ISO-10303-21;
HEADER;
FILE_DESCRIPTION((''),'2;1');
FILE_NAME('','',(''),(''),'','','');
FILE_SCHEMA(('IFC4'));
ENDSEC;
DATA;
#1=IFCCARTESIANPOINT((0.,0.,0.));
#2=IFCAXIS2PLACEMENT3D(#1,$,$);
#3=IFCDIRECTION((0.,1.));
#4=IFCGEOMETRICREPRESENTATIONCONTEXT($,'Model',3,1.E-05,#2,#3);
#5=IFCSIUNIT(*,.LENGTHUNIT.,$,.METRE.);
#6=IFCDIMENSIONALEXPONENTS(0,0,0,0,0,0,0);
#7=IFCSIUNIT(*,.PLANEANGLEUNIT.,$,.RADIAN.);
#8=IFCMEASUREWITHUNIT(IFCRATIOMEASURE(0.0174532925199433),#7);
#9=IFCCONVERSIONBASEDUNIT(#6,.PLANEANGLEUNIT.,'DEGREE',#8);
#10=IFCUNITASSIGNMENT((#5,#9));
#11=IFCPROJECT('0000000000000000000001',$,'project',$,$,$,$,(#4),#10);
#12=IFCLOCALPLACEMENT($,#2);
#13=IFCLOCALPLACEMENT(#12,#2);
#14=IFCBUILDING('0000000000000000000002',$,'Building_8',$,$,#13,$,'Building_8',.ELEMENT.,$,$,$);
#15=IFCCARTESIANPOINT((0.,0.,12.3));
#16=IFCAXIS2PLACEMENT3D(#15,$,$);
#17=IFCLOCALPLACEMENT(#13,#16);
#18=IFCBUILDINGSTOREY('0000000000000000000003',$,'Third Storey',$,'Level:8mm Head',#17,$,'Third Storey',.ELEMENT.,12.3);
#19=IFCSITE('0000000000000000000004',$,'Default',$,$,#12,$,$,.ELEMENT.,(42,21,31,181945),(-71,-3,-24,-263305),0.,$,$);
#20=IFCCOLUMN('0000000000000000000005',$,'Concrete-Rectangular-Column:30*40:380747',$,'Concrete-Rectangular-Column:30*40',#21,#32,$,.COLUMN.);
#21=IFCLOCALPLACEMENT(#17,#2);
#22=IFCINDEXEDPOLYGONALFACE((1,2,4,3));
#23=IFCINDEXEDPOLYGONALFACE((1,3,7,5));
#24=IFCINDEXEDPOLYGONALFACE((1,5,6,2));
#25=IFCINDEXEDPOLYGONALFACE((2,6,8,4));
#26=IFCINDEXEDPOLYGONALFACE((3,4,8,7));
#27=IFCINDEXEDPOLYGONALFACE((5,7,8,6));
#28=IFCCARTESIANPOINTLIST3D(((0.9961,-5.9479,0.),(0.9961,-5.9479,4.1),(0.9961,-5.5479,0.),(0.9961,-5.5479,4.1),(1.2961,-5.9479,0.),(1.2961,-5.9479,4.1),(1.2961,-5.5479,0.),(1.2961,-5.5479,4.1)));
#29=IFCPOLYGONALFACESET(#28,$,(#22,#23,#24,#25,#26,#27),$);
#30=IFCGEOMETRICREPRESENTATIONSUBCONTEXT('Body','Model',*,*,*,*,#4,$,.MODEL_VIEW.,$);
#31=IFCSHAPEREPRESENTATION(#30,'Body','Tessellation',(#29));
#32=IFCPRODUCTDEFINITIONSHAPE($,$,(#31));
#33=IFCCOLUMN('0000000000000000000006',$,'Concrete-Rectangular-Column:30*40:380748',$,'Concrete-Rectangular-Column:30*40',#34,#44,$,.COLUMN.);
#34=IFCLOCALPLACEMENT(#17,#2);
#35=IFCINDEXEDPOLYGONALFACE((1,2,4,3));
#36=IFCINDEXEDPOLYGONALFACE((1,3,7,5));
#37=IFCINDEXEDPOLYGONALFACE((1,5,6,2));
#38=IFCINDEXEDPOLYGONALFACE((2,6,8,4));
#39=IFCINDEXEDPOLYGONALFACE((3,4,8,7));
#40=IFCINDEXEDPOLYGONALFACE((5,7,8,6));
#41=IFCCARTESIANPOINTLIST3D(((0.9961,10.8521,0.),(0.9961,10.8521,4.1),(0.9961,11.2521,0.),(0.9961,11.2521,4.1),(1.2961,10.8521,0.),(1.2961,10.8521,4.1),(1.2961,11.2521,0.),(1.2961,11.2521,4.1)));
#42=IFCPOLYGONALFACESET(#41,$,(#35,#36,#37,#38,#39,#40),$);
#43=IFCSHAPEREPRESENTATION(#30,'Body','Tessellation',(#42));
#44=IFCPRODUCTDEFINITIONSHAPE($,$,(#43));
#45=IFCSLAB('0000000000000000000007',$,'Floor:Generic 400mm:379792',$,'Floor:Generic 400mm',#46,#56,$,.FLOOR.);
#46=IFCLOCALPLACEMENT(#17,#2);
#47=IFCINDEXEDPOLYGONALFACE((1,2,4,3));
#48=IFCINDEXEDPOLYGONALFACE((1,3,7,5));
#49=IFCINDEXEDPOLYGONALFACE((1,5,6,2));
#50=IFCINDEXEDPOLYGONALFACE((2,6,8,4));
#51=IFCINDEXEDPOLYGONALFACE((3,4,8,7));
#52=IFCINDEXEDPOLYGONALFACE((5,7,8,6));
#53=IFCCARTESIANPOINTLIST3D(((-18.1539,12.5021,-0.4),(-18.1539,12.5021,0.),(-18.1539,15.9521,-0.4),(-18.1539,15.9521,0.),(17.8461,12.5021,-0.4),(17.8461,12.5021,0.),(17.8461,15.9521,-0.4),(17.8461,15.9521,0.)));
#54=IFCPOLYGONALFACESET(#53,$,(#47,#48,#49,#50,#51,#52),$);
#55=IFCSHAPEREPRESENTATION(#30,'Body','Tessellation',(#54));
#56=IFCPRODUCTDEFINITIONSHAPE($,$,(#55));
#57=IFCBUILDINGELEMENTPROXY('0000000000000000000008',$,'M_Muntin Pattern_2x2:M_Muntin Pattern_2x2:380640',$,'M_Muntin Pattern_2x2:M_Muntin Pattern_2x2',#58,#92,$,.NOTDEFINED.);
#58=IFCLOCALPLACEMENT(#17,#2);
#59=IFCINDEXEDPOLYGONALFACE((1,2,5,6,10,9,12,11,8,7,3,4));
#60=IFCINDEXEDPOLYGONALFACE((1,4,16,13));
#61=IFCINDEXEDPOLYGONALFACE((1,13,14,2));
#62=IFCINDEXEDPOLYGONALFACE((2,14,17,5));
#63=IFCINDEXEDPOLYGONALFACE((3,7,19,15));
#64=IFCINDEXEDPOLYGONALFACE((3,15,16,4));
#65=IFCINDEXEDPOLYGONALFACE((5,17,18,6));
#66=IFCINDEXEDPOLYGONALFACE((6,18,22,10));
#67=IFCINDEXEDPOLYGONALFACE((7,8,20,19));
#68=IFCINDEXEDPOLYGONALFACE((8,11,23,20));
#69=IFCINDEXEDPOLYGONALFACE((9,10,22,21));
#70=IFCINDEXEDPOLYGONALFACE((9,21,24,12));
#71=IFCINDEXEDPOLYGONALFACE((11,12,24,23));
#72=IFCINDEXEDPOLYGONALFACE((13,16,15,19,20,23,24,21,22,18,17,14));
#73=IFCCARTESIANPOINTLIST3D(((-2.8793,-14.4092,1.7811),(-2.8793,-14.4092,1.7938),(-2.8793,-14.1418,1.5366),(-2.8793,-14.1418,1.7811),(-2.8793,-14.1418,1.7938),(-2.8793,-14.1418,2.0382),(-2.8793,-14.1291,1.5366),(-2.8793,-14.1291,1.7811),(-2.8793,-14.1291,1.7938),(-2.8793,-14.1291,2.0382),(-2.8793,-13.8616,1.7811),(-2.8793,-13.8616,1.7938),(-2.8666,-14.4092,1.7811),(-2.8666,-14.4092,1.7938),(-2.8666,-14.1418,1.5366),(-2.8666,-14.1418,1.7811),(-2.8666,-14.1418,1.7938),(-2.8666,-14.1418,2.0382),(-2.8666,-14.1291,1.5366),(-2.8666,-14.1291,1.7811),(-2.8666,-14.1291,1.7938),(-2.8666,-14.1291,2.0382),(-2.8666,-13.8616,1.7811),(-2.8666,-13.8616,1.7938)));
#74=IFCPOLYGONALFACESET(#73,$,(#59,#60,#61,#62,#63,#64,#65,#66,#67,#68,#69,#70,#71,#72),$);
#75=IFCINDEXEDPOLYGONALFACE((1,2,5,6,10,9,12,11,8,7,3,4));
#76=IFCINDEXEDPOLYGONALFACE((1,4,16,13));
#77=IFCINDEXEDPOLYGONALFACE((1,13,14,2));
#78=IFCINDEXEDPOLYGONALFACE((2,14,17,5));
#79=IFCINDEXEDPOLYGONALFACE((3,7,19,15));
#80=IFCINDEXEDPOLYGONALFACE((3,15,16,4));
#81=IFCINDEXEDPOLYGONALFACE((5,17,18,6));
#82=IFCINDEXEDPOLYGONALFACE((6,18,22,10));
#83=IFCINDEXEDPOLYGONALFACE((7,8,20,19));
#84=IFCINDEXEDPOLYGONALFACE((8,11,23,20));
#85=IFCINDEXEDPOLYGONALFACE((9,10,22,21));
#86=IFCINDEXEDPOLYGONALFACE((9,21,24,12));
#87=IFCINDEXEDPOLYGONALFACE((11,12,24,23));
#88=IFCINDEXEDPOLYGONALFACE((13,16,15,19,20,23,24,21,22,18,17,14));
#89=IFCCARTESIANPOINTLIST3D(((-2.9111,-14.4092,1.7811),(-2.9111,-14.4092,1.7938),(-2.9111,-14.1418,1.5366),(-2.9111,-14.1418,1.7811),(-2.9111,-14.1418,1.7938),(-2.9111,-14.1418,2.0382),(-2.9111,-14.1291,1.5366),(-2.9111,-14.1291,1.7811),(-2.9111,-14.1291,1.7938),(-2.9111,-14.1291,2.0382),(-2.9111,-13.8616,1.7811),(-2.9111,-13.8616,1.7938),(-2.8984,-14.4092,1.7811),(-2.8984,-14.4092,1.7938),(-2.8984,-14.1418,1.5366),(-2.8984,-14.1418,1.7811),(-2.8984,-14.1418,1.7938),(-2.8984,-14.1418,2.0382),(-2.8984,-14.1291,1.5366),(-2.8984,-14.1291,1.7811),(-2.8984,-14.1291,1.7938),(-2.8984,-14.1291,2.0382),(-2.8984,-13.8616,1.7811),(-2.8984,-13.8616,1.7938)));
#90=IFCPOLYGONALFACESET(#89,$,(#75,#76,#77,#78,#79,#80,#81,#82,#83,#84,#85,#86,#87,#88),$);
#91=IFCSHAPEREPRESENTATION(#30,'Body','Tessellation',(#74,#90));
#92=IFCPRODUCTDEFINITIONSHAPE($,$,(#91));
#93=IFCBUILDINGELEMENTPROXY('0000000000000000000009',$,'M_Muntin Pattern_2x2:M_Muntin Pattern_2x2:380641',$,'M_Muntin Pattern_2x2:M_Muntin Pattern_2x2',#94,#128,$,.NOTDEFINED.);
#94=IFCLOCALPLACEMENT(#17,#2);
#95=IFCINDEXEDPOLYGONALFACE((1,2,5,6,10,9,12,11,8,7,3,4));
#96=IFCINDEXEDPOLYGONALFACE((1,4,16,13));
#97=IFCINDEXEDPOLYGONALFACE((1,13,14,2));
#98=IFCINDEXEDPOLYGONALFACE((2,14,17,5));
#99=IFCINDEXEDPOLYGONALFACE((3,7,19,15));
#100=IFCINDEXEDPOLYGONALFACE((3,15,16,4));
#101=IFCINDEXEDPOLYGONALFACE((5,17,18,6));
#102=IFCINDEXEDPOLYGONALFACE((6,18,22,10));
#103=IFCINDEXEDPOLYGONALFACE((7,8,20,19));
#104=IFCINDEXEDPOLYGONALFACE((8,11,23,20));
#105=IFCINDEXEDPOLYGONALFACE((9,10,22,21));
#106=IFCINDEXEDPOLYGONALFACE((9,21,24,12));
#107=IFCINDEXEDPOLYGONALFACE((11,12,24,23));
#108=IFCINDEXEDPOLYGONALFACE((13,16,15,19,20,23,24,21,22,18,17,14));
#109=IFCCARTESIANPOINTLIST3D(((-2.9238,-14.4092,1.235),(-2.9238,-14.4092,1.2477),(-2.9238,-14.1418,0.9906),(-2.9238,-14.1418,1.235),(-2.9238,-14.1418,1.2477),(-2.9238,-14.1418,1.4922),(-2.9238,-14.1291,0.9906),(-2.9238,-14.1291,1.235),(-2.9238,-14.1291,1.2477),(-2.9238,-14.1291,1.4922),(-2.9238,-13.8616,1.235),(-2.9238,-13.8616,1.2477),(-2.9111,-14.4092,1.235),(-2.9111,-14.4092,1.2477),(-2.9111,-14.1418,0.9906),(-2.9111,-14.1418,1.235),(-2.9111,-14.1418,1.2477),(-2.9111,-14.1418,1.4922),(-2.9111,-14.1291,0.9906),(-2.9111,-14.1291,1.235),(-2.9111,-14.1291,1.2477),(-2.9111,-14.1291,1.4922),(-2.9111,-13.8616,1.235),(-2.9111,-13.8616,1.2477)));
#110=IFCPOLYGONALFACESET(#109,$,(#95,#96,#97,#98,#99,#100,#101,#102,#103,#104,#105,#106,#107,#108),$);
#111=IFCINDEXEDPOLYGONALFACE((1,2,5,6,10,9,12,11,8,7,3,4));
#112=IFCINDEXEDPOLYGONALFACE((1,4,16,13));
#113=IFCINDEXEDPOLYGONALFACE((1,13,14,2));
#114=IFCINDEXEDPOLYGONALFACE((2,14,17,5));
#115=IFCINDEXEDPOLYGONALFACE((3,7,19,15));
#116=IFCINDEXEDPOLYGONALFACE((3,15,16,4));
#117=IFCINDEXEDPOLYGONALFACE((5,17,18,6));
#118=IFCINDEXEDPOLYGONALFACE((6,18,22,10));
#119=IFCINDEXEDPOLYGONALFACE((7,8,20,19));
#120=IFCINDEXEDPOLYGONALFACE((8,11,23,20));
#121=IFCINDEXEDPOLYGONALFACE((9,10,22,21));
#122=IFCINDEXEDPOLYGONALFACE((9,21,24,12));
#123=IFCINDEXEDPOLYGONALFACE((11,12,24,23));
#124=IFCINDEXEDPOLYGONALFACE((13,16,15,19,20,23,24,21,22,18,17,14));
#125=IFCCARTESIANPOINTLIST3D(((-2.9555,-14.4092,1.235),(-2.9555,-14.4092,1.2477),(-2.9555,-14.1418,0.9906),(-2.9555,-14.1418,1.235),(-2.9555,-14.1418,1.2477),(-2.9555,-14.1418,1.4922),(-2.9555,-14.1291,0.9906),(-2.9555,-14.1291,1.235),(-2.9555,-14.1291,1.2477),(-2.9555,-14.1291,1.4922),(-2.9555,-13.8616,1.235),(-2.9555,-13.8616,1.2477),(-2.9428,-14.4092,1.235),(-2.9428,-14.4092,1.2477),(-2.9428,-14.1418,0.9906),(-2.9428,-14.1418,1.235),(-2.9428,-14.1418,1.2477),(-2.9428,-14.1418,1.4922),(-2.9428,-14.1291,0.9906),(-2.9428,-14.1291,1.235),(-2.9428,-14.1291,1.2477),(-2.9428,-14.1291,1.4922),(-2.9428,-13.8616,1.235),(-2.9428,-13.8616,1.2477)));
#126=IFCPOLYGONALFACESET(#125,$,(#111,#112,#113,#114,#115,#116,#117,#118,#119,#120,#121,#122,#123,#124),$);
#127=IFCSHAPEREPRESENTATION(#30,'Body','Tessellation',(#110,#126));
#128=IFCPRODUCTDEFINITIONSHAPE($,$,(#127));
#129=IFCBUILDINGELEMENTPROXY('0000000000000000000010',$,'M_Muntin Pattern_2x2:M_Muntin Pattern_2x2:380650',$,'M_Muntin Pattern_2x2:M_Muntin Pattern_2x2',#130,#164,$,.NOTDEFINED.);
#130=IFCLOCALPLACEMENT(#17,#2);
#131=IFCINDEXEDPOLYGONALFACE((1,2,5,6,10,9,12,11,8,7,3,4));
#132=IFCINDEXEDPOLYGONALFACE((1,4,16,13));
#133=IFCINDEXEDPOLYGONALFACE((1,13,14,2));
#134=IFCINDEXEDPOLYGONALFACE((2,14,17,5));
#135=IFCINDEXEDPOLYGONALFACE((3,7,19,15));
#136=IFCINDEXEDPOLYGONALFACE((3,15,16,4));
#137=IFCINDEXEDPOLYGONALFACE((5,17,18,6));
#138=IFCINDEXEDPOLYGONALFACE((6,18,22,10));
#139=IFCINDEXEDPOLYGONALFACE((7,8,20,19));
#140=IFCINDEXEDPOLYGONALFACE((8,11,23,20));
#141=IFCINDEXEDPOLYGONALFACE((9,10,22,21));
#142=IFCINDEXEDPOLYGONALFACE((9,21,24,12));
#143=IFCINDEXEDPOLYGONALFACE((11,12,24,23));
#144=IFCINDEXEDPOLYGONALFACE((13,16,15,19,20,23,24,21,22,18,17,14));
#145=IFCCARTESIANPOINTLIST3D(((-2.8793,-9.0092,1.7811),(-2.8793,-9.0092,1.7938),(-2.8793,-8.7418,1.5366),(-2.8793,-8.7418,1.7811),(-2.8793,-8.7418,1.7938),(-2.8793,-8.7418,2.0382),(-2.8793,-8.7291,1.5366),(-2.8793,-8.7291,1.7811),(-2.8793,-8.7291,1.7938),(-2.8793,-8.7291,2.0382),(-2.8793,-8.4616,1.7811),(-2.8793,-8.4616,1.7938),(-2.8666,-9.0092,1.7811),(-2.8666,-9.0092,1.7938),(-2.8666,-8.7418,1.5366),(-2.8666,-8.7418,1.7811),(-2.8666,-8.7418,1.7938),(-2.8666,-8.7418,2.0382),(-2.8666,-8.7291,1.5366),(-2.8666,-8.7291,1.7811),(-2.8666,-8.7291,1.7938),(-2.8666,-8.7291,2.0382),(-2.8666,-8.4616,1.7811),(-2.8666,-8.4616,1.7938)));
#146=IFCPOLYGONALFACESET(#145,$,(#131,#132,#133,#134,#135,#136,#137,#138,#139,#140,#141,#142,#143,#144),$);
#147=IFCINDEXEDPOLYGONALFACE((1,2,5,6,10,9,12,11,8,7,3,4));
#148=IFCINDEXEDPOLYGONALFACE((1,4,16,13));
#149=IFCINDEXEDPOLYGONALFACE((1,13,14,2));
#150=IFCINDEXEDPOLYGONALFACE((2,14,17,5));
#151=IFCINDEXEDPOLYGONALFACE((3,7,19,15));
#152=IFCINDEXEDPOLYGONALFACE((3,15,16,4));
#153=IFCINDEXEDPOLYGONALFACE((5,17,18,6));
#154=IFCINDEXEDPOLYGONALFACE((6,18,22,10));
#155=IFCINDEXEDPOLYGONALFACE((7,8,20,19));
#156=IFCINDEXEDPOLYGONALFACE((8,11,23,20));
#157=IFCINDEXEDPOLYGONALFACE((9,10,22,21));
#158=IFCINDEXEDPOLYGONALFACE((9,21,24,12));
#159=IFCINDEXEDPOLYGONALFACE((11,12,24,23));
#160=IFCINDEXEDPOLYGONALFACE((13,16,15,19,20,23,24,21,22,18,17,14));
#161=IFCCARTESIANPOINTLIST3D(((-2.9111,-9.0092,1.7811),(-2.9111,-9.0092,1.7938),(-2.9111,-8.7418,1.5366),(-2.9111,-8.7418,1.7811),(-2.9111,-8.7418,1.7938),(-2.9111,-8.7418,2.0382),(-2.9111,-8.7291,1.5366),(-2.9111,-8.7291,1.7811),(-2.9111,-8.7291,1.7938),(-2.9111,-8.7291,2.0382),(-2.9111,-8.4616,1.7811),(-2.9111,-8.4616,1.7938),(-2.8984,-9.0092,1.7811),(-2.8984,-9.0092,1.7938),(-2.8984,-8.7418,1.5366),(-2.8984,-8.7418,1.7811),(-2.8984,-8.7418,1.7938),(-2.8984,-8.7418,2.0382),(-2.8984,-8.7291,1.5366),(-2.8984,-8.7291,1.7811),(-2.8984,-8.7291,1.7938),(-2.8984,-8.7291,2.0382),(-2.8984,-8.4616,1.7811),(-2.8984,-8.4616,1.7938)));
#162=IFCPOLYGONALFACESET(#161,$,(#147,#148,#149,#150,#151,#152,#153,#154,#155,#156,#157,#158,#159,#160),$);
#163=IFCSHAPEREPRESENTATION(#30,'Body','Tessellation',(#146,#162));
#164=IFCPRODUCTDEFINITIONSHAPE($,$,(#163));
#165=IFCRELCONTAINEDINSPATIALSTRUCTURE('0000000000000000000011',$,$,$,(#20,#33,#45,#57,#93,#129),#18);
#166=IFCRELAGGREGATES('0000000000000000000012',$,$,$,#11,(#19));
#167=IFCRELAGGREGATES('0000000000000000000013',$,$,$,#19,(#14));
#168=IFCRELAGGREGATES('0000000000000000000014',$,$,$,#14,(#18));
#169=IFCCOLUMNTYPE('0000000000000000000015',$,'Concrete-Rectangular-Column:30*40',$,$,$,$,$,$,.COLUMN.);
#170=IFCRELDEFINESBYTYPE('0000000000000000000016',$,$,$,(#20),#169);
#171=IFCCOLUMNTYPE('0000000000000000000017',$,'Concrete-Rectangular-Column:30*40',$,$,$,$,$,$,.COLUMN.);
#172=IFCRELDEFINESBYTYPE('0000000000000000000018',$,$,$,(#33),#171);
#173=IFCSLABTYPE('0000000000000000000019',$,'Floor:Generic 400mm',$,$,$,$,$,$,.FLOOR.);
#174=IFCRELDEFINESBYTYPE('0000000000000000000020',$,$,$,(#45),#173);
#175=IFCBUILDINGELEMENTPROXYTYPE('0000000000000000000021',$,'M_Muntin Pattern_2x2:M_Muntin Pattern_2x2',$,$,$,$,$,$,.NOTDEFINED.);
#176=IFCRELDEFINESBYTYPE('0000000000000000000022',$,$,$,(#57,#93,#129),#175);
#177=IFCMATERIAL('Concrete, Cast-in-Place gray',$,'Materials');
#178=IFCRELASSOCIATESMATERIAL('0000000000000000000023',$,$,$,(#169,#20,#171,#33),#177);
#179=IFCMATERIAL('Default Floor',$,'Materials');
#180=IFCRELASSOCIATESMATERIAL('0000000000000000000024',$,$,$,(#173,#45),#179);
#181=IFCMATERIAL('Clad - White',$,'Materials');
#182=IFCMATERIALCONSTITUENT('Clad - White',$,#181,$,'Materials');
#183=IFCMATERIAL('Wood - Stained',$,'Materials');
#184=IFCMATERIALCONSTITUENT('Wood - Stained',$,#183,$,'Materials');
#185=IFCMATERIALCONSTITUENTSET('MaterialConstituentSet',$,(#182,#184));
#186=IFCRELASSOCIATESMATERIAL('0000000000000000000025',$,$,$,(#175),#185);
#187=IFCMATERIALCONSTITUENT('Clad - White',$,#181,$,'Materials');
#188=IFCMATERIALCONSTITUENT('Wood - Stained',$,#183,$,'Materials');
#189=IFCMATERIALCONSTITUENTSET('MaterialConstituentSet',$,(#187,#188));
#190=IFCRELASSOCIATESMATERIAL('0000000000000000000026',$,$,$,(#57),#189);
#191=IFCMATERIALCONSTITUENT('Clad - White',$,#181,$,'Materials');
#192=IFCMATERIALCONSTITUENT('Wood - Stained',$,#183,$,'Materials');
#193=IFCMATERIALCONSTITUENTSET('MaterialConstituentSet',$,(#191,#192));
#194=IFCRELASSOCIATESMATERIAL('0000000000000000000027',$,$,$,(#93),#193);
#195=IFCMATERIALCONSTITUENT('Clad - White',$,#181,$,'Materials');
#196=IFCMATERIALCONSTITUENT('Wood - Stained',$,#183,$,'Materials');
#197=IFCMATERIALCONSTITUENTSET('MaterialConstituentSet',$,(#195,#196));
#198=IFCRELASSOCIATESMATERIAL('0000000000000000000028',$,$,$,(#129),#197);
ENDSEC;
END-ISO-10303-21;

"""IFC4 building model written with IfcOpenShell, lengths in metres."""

from ifc_helpers import new_model, entity, si_unit, converted_unit, direction, frame, origin, place, context, subcontext, project, spatial, indexed_curve, outline, extrude, source, transform, mapped, material, constituent, constituent_set, type_object, type_shapes, element, save


model = new_model("IFC4")

# Units and contexts
model_context = context("Model", 3, precision=1e-05, world=origin(), true_north=direction((0.0, 1.0)))
body_context = subcontext(model_context, "Body", "Model", "MODEL_VIEW")
ifc_project = project(units=[si_unit("LENGTHUNIT", "METRE"), converted_unit("PLANEANGLEUNIT", "DEGREE", entity("IfcRatioMeasure", 0.0174532925199433), si_unit("PLANEANGLEUNIT", "RADIAN"), dimensions=[0, 0, 0, 0, 0, 0, 0])], contexts=[model_context])

# Site, building, storey
site_placement = place(None, origin())
site = spatial("IfcSite", under=ifc_project, at=site_placement, Name="Default", CompositionType="ELEMENT", RefLatitude=(42, 21, 31, 181945), RefLongitude=(-71, -3, -24, -263305), RefElevation=0.0)
building_placement = place(site_placement, origin())
building = spatial("IfcBuilding", under=site, at=building_placement, Name="Building_8", LongName="Building_8", CompositionType="ELEMENT")
storey_placement = place(building_placement, frame((0.0, 0.0, 12.3)))
storey = spatial("IfcBuildingStorey", under=building, at=storey_placement, Name="Third Storey", ObjectType="Level:8mm Head", LongName="Third Storey", CompositionType="ELEMENT", Elevation=12.3)

# Columns
ifc_material_1 = material(Name="Concrete, Cast-in-Place gray", Category="Materials")
column_type_1 = type_object("IfcColumnType", Name="Concrete-Rectangular-Column:30*40", PredefinedType="COLUMN", material=ifc_material_1)
shared_shape_1 = source(origin(), body_context, "Body", "SweptSolid", [
    extrude(outline(indexed_curve([(-0.2, -0.15), (0.2, -0.15), (0.2, 0.15), (-0.2, 0.15), (-0.2, -0.15)], self_intersect=False)), frame((1.1461, -5.7479, 12.3), z_axis=(0.0, 0.0, 1.0), x_axis=(0.0, -1.0, 0.0)), (0.0, 0.0, 1.0), 4.1),
])
type_shapes(column_type_1, [shared_shape_1])
column_1_placement = place(storey_placement, frame((0.0, 0.0, -12.3)))
element("IfcColumn", 1, at=column_1_placement, inside=storey, type_object=column_type_1, material=ifc_material_1, Name="Concrete-Rectangular-Column:30*40:380747", ObjectType="Concrete-Rectangular-Column:30*40", PredefinedType="COLUMN", context=body_context, shape_type="MappedRepresentation", body=[
    mapped(shared_shape_1, transform((0.0, 0.0, 0.0), scale=1.0)),
])
column_type_2 = type_object("IfcColumnType", Name="Concrete-Rectangular-Column:30*40", PredefinedType="COLUMN", material=ifc_material_1)
shared_shape_2 = source(origin(), body_context, "Body", "SweptSolid", [
    extrude(outline(indexed_curve([(-0.2, -0.15), (0.2, -0.15), (0.2, 0.15), (-0.2, 0.15), (-0.2, -0.15)], self_intersect=False)), frame((1.1461, 11.0521, 12.3), z_axis=(0.0, 0.0, 1.0), x_axis=(0.0, -1.0, 0.0)), (0.0, 0.0, 1.0), 4.1),
])
type_shapes(column_type_2, [shared_shape_2])
column_2_placement = place(storey_placement, frame((0.0, 0.0, -12.3)))
element("IfcColumn", 2, at=column_2_placement, inside=storey, type_object=column_type_2, material=ifc_material_1, Name="Concrete-Rectangular-Column:30*40:380748", ObjectType="Concrete-Rectangular-Column:30*40", PredefinedType="COLUMN", context=body_context, shape_type="MappedRepresentation", body=[
    mapped(shared_shape_2, transform((0.0, 0.0, 0.0), scale=1.0)),
])

# Slab
ifc_material_2 = material(Name="Default Floor", Category="Materials")
slab_type_1 = type_object("IfcSlabType", Name="Floor:Generic 400mm", PredefinedType="FLOOR", material=ifc_material_2)
slab_1_placement = place(storey_placement, origin())
element("IfcSlab", 3, at=slab_1_placement, inside=storey, type_object=slab_type_1, material=ifc_material_2, Name="Floor:Generic 400mm:379792", ObjectType="Floor:Generic 400mm", PredefinedType="FLOOR", context=body_context, shape_type="SweptSolid", body=[
    extrude(outline(indexed_curve([(-1.725, -18.0), (1.725, -18.0), (1.725, 18.0), (-1.725, 18.0), (-1.725, -18.0)], self_intersect=False)), frame((-0.1539, 14.2271, 0.0), z_axis=(0.0, 0.0, -1.0), x_axis=(0.0, 1.0, 0.0)), (0.0, 0.0, 1.0), 0.4),
])

# Building element proxies
ifc_material_3 = material(Name="Clad - White", Category="Materials")
ifc_constituent_1 = constituent(ifc_material_3, Name="Clad - White", Category="Materials")
ifc_material_4 = material(Name="Wood - Stained", Category="Materials")
ifc_constituent_2 = constituent(ifc_material_4, Name="Wood - Stained", Category="Materials")
ifc_constituent_set_1 = constituent_set(constituents=[ifc_constituent_1, ifc_constituent_2], Name="MaterialConstituentSet")
ifc_constituent_3 = constituent(ifc_material_3, Name="Clad - White", Category="Materials")
ifc_constituent_4 = constituent(ifc_material_4, Name="Wood - Stained", Category="Materials")
ifc_constituent_set_2 = constituent_set(constituents=[ifc_constituent_3, ifc_constituent_4], Name="MaterialConstituentSet")
building_element_proxy_type_1 = type_object("IfcBuildingElementProxyType", Name="M_Muntin Pattern_2x2:M_Muntin Pattern_2x2", PredefinedType="NOTDEFINED", material=ifc_constituent_set_2)
shared_shape_3 = source(origin(), body_context, "Body", "SweptSolid", [
    extrude(outline(indexed_curve([(0.0064, -0.0064), (0.2508, -0.0064), (0.2508, 0.0063), (0.0064, 0.0063), (0.0064, 0.2738), (-0.0063, 0.2738), (-0.0063, 0.0063), (-0.2508, 0.0063), (-0.2508, -0.0064), (-0.0063, -0.0064), (-0.0063, -0.2738), (0.0064, -0.2738), (0.0064, -0.0064)], self_intersect=False)), frame((0.0, 0.0095, 0.2508), z_axis=(0.0, 1.0, 0.0), x_axis=(0.0, 0.0, 1.0)), (0.0, 0.0, 1.0), 0.0127),
    extrude(outline(indexed_curve([(0.0064, -0.0064), (0.2508, -0.0064), (0.2508, 0.0063), (0.0064, 0.0063), (0.0064, 0.2738), (-0.0063, 0.2738), (-0.0063, 0.0063), (-0.2508, 0.0063), (-0.2508, -0.0064), (-0.0063, -0.0064), (-0.0063, -0.2738), (0.0064, -0.2738), (0.0064, -0.0064)], self_intersect=False)), frame((0.0, -0.0222, 0.2508), z_axis=(0.0, 1.0, 0.0), x_axis=(0.0, 0.0, 1.0)), (0.0, 0.0, 1.0), 0.0127),
])
type_shapes(building_element_proxy_type_1, [shared_shape_3])
proxy_1_placement = place(storey_placement, frame((-2.8888, -14.1354, 1.5366), z_axis=(0.0, 0.0, 1.0), x_axis=(0.0, -1.0, 0.0)))
element("IfcBuildingElementProxy", 4, at=proxy_1_placement, inside=storey, type_object=building_element_proxy_type_1, material=ifc_constituent_set_1, Name="M_Muntin Pattern_2x2:M_Muntin Pattern_2x2:380640", ObjectType="M_Muntin Pattern_2x2:M_Muntin Pattern_2x2", PredefinedType="NOTDEFINED", context=body_context, shape_type="MappedRepresentation", body=[
    mapped(shared_shape_3, transform((0.0, 0.0, 0.0), scale=1.0)),
])
ifc_constituent_5 = constituent(ifc_material_3, Name="Clad - White", Category="Materials")
ifc_constituent_6 = constituent(ifc_material_4, Name="Wood - Stained", Category="Materials")
ifc_constituent_set_3 = constituent_set(constituents=[ifc_constituent_5, ifc_constituent_6], Name="MaterialConstituentSet")
proxy_2_placement = place(storey_placement, frame((-2.9333, -14.1354, 0.9906), z_axis=(0.0, 0.0, 1.0), x_axis=(0.0, -1.0, 0.0)))
element("IfcBuildingElementProxy", 5, at=proxy_2_placement, inside=storey, type_object=building_element_proxy_type_1, material=ifc_constituent_set_3, Name="M_Muntin Pattern_2x2:M_Muntin Pattern_2x2:380641", ObjectType="M_Muntin Pattern_2x2:M_Muntin Pattern_2x2", PredefinedType="NOTDEFINED", context=body_context, shape_type="MappedRepresentation", body=[
    mapped(shared_shape_3, transform((0.0, 0.0, 0.0), scale=1.0)),
])
ifc_constituent_7 = constituent(ifc_material_3, Name="Clad - White", Category="Materials")
ifc_constituent_8 = constituent(ifc_material_4, Name="Wood - Stained", Category="Materials")
ifc_constituent_set_4 = constituent_set(constituents=[ifc_constituent_7, ifc_constituent_8], Name="MaterialConstituentSet")
proxy_3_placement = place(storey_placement, frame((-2.8888, -8.7354, 1.5366), z_axis=(0.0, 0.0, 1.0), x_axis=(0.0, -1.0, 0.0)))
element("IfcBuildingElementProxy", 6, at=proxy_3_placement, inside=storey, type_object=building_element_proxy_type_1, material=ifc_constituent_set_4, Name="M_Muntin Pattern_2x2:M_Muntin Pattern_2x2:380650", ObjectType="M_Muntin Pattern_2x2:M_Muntin Pattern_2x2", PredefinedType="NOTDEFINED", context=body_context, shape_type="MappedRepresentation", body=[
    mapped(shared_shape_3, transform((0.0, 0.0, 0.0), scale=1.0)),
])

save(model, "model.ifc")
